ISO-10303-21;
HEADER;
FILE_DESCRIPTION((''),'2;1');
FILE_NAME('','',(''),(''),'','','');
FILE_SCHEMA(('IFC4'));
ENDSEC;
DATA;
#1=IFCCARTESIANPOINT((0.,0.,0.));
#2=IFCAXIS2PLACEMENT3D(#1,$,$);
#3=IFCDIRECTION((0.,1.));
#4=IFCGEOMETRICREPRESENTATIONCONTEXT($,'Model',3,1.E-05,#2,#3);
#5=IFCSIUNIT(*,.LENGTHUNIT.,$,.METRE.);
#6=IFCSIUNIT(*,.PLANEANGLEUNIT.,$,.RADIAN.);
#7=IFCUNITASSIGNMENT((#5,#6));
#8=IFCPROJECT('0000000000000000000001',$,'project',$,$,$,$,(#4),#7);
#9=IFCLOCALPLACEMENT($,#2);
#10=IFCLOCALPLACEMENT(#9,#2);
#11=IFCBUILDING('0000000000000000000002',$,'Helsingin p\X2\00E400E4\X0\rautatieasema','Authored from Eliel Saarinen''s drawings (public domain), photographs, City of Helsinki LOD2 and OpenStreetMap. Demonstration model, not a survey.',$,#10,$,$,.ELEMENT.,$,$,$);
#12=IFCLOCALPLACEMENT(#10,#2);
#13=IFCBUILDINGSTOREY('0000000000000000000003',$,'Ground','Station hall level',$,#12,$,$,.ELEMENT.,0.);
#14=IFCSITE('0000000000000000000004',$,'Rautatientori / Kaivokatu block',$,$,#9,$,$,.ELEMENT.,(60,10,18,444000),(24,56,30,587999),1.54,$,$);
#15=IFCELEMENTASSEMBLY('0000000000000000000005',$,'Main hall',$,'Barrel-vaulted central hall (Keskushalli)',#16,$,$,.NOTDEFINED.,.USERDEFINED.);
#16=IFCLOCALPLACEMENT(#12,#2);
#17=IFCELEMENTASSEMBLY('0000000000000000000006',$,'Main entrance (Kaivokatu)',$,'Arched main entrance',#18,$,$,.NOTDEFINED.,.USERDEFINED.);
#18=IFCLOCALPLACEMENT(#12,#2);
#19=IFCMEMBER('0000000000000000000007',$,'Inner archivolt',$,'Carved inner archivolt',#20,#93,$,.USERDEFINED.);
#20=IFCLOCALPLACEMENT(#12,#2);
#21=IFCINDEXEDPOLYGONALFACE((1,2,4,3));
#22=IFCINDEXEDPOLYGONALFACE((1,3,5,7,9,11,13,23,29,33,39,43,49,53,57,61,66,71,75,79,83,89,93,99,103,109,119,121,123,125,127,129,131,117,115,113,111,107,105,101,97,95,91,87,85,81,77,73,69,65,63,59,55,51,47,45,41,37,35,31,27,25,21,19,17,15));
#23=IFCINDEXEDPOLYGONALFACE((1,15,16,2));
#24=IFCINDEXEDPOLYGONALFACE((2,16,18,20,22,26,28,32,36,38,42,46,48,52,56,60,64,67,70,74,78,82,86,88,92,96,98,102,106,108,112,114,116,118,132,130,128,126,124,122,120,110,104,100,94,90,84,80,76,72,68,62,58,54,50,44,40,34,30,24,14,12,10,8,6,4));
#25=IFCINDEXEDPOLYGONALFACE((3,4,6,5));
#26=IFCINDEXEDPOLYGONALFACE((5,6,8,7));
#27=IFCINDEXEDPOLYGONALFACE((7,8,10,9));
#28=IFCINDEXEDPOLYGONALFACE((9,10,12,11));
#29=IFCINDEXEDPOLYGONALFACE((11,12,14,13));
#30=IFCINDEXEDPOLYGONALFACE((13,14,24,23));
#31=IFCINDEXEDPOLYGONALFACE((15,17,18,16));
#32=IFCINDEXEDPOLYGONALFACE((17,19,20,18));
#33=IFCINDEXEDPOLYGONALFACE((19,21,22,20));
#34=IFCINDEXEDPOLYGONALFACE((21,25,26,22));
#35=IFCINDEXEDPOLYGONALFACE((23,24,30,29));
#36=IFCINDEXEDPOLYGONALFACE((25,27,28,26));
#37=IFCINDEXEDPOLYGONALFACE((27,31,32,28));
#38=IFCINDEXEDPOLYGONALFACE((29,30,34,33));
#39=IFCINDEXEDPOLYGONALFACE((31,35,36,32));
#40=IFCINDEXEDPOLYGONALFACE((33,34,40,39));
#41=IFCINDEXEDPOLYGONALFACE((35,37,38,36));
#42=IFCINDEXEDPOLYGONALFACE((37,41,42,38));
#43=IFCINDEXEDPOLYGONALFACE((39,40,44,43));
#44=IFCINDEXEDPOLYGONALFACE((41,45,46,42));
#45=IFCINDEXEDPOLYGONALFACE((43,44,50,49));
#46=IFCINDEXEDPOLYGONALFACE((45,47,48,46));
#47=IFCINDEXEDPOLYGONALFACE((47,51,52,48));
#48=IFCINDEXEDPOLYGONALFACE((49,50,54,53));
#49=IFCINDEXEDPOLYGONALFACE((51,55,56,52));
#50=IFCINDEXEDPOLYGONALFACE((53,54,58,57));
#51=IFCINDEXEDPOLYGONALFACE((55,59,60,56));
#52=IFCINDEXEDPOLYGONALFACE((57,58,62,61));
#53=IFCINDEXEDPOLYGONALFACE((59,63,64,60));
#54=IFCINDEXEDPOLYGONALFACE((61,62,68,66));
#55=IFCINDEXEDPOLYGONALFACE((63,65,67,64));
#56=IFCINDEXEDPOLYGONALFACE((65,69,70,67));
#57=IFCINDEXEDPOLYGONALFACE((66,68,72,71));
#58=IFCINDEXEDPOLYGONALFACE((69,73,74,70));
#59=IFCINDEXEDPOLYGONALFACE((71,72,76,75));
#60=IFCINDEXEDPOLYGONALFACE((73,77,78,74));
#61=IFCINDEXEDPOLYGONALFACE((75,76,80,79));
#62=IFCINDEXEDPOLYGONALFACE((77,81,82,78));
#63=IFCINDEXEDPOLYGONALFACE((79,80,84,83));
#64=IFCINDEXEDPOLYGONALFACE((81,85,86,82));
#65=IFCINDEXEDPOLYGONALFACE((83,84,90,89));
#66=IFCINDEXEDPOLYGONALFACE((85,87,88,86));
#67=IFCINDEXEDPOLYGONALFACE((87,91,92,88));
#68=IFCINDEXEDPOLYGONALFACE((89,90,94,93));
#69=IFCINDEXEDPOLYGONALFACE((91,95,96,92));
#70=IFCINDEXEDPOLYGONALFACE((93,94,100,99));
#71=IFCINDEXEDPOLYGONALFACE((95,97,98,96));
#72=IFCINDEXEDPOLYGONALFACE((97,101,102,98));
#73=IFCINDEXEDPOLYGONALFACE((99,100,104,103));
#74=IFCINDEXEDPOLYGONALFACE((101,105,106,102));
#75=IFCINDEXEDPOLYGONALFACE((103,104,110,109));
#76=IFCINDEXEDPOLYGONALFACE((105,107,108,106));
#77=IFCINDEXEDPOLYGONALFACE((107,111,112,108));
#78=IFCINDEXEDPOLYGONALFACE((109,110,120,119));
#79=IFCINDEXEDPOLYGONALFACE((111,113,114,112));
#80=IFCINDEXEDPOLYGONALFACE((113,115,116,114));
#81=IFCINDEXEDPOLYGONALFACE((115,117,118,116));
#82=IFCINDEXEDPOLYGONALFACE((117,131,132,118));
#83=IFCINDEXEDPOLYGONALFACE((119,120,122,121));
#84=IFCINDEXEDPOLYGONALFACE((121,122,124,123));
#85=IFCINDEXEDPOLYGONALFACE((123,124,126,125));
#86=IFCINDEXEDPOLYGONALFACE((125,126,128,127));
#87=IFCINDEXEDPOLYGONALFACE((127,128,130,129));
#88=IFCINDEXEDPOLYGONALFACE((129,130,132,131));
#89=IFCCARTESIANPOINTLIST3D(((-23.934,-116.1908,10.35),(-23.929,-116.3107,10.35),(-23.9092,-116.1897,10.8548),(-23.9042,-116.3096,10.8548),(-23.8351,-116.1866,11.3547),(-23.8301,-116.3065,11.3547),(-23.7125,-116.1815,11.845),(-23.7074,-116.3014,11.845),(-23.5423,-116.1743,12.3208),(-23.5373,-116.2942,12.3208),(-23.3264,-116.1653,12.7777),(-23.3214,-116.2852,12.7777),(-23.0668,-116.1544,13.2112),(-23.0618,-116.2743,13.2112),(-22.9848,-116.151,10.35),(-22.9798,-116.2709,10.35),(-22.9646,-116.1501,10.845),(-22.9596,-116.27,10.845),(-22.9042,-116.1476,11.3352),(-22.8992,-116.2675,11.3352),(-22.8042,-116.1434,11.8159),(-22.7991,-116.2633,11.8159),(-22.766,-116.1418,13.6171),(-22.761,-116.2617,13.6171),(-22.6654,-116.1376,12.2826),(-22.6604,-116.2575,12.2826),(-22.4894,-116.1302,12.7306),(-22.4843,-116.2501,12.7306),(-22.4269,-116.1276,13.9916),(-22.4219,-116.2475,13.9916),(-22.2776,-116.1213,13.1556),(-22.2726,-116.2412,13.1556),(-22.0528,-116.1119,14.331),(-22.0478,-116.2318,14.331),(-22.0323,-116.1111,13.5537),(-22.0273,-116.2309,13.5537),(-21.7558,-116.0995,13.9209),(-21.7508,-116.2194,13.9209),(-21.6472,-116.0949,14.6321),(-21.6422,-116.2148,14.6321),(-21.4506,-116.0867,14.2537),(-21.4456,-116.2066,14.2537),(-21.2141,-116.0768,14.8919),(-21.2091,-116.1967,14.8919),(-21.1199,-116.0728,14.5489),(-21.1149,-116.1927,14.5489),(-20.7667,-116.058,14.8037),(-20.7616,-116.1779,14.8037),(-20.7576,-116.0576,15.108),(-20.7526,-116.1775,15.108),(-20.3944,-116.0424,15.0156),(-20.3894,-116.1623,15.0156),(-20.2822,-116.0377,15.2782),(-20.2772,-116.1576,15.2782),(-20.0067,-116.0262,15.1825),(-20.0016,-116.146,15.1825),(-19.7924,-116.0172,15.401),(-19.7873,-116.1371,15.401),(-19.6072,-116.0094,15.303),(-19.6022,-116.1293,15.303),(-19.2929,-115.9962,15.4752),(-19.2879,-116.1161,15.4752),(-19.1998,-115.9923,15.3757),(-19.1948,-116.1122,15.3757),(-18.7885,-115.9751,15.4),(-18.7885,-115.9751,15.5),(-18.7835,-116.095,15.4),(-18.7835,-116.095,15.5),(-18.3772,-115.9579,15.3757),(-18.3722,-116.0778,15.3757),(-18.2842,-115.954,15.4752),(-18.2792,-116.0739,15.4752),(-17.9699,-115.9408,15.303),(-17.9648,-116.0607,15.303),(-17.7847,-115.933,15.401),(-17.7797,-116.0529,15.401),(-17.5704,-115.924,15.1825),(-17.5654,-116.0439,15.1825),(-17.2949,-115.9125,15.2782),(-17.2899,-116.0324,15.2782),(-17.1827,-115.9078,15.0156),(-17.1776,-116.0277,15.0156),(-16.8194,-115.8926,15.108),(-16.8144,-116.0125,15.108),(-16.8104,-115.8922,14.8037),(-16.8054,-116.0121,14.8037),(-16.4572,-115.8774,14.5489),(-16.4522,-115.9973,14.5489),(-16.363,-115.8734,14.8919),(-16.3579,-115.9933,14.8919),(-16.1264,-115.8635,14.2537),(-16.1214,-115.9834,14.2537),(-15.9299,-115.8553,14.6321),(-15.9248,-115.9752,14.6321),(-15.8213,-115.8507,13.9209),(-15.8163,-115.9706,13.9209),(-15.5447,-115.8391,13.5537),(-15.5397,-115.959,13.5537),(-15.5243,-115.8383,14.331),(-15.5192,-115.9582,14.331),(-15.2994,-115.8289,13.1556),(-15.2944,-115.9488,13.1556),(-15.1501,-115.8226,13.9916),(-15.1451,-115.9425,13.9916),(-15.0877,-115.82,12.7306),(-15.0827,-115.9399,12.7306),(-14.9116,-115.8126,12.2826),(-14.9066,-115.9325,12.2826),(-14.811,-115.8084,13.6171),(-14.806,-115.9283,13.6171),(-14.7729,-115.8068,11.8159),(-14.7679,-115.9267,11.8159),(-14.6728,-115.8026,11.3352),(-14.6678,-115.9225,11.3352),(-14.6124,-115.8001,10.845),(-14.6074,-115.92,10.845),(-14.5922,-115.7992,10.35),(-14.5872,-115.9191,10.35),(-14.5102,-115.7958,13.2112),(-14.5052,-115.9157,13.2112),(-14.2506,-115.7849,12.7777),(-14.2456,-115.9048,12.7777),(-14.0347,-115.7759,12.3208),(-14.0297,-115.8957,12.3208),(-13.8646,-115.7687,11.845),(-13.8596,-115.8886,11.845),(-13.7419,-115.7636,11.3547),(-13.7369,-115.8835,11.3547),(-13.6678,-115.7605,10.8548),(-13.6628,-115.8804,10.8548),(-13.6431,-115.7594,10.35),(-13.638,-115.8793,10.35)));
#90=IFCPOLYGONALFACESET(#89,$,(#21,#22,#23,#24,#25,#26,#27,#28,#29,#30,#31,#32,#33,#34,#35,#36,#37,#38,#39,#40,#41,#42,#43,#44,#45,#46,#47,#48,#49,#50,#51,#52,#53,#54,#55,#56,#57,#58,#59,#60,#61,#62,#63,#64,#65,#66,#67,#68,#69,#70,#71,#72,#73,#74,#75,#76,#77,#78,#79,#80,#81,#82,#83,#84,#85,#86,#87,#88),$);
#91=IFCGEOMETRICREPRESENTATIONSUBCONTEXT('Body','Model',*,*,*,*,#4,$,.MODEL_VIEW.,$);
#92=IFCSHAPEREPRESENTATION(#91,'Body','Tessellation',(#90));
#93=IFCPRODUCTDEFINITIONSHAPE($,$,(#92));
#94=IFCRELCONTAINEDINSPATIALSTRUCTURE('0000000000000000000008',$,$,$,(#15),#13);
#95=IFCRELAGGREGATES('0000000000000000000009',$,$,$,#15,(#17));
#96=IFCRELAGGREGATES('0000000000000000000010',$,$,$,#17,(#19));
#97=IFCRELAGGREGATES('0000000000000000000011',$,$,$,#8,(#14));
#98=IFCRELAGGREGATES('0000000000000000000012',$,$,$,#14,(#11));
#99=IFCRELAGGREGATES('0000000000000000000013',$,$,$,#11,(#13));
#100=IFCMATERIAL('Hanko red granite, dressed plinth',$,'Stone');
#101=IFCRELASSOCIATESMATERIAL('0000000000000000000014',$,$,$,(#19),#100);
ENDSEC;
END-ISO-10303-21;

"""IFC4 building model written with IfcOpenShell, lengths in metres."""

from ifc_helpers import new_model, si_unit, direction, frame, origin, place, context, subcontext, project, spatial, polyline, outline, extrude, material, element, aggregate, save


model = new_model("IFC4")

# Units and contexts
model_context = context("Model", 3, precision=1e-05, world=origin(), true_north=direction((0.0, 1.0)))
body_context = subcontext(model_context, "Body", "Model", "MODEL_VIEW")
ifc_project = project(units=[si_unit("LENGTHUNIT", "METRE"), si_unit("PLANEANGLEUNIT", "RADIAN")], contexts=[model_context])

# Site, building, storey
site_placement = place(None, origin())
site = spatial("IfcSite", under=ifc_project, at=site_placement, Name="Rautatientori / Kaivokatu block", CompositionType="ELEMENT", RefLatitude=(60, 10, 18, 444000), RefLongitude=(24, 56, 30, 587999), RefElevation=1.54)
building_placement = place(site_placement, origin())
building = spatial("IfcBuilding", under=site, at=building_placement, Name="Helsingin päärautatieasema", Description="Authored from Eliel Saarinen's drawings (public domain), photographs, City of Helsinki LOD2 and OpenStreetMap. Demonstration model, not a survey.", CompositionType="ELEMENT")
storey_placement = place(building_placement, origin())
storey = spatial("IfcBuildingStorey", under=building, at=storey_placement, Name="Ground", Description="Station hall level", CompositionType="ELEMENT", Elevation=0.0)

# Shared definitions
ifc_material_1 = material(Name="Hanko red granite, dressed plinth", Category="Stone")

# Element assemblies, member
assembly_1_placement = place(building_placement, origin())
assembly_1 = element("IfcElementAssembly", 1, at=assembly_1_placement, inside=storey, Name="Main hall", ObjectType="Barrel-vaulted central hall (Keskushalli)", AssemblyPlace="NOTDEFINED", PredefinedType="USERDEFINED")
assembly_2_placement = place(building_placement, origin())
assembly_2 = element("IfcElementAssembly", 2, at=assembly_2_placement, Name="Main entrance (Kaivokatu)", ObjectType="Arched main entrance", AssemblyPlace="NOTDEFINED", PredefinedType="USERDEFINED")
member_1_placement = place(building_placement, origin())
member_1 = element("IfcMember", 3, at=member_1_placement, material=ifc_material_1, Name="Inner archivolt", ObjectType="Carved inner archivolt", PredefinedType="USERDEFINED", context=body_context, shape_type="SweptSolid", body=[
    extrude(outline(polyline([(5.15, 10.35), (5.1252, 10.8548), (5.051, 11.3547), (4.9282, 11.845), (4.758, 12.3208), (4.5419, 12.7777), (4.2821, 13.2112), (3.981, 13.6171), (3.6416, 13.9916), (3.2671, 14.331), (2.8612, 14.6321), (2.4277, 14.8919), (1.9708, 15.108), (1.495, 15.2782), (1.0047, 15.401), (0.5048, 15.4752), (0.0, 15.5), (-0.5048, 15.4752), (-1.0047, 15.401), (-1.495, 15.2782), (-1.9708, 15.108), (-2.4277, 14.8919), (-2.8612, 14.6321), (-3.2671, 14.331), (-3.6416, 13.9916), (-3.981, 13.6171), (-4.2821, 13.2112), (-4.5419, 12.7777), (-4.758, 12.3208), (-4.9282, 11.845), (-5.051, 11.3547), (-5.1252, 10.8548), (-5.15, 10.35), (-4.2, 10.35), (-4.1798, 10.845), (-4.1193, 11.3352), (-4.0191, 11.8159), (-3.8803, 12.2826), (-3.7041, 12.7306), (-3.4922, 13.1556), (-3.2466, 13.5537), (-2.9698, 13.9209), (-2.6645, 14.2537), (-2.3334, 14.5489), (-1.9799, 14.8037), (-1.6073, 15.0156), (-1.2192, 15.1825), (-0.8194, 15.303), (-0.4117, 15.3757), (0.0, 15.4), (0.4117, 15.3757), (0.8194, 15.303), (1.2192, 15.1825), (1.6073, 15.0156), (1.9799, 14.8037), (2.3334, 14.5489), (2.6645, 14.2537), (2.9698, 13.9209), (3.2466, 13.5537), (3.4922, 13.1556), (3.7041, 12.7306), (3.8803, 12.2826), (4.0191, 11.8159), (4.1193, 11.3352), (4.1798, 10.845), (4.2, 10.35), (5.15, 10.35)])), frame((-18.7885, -115.9751, 0.0), z_axis=(0.041876, -0.999123, 0.0), x_axis=(0.999123, 0.041876, 0.0)), (0.0, 0.0, 1.0), 0.12),
])
aggregate(assembly_1, [assembly_2])
aggregate(assembly_2, [member_1])

save(model, "model.ifc")
